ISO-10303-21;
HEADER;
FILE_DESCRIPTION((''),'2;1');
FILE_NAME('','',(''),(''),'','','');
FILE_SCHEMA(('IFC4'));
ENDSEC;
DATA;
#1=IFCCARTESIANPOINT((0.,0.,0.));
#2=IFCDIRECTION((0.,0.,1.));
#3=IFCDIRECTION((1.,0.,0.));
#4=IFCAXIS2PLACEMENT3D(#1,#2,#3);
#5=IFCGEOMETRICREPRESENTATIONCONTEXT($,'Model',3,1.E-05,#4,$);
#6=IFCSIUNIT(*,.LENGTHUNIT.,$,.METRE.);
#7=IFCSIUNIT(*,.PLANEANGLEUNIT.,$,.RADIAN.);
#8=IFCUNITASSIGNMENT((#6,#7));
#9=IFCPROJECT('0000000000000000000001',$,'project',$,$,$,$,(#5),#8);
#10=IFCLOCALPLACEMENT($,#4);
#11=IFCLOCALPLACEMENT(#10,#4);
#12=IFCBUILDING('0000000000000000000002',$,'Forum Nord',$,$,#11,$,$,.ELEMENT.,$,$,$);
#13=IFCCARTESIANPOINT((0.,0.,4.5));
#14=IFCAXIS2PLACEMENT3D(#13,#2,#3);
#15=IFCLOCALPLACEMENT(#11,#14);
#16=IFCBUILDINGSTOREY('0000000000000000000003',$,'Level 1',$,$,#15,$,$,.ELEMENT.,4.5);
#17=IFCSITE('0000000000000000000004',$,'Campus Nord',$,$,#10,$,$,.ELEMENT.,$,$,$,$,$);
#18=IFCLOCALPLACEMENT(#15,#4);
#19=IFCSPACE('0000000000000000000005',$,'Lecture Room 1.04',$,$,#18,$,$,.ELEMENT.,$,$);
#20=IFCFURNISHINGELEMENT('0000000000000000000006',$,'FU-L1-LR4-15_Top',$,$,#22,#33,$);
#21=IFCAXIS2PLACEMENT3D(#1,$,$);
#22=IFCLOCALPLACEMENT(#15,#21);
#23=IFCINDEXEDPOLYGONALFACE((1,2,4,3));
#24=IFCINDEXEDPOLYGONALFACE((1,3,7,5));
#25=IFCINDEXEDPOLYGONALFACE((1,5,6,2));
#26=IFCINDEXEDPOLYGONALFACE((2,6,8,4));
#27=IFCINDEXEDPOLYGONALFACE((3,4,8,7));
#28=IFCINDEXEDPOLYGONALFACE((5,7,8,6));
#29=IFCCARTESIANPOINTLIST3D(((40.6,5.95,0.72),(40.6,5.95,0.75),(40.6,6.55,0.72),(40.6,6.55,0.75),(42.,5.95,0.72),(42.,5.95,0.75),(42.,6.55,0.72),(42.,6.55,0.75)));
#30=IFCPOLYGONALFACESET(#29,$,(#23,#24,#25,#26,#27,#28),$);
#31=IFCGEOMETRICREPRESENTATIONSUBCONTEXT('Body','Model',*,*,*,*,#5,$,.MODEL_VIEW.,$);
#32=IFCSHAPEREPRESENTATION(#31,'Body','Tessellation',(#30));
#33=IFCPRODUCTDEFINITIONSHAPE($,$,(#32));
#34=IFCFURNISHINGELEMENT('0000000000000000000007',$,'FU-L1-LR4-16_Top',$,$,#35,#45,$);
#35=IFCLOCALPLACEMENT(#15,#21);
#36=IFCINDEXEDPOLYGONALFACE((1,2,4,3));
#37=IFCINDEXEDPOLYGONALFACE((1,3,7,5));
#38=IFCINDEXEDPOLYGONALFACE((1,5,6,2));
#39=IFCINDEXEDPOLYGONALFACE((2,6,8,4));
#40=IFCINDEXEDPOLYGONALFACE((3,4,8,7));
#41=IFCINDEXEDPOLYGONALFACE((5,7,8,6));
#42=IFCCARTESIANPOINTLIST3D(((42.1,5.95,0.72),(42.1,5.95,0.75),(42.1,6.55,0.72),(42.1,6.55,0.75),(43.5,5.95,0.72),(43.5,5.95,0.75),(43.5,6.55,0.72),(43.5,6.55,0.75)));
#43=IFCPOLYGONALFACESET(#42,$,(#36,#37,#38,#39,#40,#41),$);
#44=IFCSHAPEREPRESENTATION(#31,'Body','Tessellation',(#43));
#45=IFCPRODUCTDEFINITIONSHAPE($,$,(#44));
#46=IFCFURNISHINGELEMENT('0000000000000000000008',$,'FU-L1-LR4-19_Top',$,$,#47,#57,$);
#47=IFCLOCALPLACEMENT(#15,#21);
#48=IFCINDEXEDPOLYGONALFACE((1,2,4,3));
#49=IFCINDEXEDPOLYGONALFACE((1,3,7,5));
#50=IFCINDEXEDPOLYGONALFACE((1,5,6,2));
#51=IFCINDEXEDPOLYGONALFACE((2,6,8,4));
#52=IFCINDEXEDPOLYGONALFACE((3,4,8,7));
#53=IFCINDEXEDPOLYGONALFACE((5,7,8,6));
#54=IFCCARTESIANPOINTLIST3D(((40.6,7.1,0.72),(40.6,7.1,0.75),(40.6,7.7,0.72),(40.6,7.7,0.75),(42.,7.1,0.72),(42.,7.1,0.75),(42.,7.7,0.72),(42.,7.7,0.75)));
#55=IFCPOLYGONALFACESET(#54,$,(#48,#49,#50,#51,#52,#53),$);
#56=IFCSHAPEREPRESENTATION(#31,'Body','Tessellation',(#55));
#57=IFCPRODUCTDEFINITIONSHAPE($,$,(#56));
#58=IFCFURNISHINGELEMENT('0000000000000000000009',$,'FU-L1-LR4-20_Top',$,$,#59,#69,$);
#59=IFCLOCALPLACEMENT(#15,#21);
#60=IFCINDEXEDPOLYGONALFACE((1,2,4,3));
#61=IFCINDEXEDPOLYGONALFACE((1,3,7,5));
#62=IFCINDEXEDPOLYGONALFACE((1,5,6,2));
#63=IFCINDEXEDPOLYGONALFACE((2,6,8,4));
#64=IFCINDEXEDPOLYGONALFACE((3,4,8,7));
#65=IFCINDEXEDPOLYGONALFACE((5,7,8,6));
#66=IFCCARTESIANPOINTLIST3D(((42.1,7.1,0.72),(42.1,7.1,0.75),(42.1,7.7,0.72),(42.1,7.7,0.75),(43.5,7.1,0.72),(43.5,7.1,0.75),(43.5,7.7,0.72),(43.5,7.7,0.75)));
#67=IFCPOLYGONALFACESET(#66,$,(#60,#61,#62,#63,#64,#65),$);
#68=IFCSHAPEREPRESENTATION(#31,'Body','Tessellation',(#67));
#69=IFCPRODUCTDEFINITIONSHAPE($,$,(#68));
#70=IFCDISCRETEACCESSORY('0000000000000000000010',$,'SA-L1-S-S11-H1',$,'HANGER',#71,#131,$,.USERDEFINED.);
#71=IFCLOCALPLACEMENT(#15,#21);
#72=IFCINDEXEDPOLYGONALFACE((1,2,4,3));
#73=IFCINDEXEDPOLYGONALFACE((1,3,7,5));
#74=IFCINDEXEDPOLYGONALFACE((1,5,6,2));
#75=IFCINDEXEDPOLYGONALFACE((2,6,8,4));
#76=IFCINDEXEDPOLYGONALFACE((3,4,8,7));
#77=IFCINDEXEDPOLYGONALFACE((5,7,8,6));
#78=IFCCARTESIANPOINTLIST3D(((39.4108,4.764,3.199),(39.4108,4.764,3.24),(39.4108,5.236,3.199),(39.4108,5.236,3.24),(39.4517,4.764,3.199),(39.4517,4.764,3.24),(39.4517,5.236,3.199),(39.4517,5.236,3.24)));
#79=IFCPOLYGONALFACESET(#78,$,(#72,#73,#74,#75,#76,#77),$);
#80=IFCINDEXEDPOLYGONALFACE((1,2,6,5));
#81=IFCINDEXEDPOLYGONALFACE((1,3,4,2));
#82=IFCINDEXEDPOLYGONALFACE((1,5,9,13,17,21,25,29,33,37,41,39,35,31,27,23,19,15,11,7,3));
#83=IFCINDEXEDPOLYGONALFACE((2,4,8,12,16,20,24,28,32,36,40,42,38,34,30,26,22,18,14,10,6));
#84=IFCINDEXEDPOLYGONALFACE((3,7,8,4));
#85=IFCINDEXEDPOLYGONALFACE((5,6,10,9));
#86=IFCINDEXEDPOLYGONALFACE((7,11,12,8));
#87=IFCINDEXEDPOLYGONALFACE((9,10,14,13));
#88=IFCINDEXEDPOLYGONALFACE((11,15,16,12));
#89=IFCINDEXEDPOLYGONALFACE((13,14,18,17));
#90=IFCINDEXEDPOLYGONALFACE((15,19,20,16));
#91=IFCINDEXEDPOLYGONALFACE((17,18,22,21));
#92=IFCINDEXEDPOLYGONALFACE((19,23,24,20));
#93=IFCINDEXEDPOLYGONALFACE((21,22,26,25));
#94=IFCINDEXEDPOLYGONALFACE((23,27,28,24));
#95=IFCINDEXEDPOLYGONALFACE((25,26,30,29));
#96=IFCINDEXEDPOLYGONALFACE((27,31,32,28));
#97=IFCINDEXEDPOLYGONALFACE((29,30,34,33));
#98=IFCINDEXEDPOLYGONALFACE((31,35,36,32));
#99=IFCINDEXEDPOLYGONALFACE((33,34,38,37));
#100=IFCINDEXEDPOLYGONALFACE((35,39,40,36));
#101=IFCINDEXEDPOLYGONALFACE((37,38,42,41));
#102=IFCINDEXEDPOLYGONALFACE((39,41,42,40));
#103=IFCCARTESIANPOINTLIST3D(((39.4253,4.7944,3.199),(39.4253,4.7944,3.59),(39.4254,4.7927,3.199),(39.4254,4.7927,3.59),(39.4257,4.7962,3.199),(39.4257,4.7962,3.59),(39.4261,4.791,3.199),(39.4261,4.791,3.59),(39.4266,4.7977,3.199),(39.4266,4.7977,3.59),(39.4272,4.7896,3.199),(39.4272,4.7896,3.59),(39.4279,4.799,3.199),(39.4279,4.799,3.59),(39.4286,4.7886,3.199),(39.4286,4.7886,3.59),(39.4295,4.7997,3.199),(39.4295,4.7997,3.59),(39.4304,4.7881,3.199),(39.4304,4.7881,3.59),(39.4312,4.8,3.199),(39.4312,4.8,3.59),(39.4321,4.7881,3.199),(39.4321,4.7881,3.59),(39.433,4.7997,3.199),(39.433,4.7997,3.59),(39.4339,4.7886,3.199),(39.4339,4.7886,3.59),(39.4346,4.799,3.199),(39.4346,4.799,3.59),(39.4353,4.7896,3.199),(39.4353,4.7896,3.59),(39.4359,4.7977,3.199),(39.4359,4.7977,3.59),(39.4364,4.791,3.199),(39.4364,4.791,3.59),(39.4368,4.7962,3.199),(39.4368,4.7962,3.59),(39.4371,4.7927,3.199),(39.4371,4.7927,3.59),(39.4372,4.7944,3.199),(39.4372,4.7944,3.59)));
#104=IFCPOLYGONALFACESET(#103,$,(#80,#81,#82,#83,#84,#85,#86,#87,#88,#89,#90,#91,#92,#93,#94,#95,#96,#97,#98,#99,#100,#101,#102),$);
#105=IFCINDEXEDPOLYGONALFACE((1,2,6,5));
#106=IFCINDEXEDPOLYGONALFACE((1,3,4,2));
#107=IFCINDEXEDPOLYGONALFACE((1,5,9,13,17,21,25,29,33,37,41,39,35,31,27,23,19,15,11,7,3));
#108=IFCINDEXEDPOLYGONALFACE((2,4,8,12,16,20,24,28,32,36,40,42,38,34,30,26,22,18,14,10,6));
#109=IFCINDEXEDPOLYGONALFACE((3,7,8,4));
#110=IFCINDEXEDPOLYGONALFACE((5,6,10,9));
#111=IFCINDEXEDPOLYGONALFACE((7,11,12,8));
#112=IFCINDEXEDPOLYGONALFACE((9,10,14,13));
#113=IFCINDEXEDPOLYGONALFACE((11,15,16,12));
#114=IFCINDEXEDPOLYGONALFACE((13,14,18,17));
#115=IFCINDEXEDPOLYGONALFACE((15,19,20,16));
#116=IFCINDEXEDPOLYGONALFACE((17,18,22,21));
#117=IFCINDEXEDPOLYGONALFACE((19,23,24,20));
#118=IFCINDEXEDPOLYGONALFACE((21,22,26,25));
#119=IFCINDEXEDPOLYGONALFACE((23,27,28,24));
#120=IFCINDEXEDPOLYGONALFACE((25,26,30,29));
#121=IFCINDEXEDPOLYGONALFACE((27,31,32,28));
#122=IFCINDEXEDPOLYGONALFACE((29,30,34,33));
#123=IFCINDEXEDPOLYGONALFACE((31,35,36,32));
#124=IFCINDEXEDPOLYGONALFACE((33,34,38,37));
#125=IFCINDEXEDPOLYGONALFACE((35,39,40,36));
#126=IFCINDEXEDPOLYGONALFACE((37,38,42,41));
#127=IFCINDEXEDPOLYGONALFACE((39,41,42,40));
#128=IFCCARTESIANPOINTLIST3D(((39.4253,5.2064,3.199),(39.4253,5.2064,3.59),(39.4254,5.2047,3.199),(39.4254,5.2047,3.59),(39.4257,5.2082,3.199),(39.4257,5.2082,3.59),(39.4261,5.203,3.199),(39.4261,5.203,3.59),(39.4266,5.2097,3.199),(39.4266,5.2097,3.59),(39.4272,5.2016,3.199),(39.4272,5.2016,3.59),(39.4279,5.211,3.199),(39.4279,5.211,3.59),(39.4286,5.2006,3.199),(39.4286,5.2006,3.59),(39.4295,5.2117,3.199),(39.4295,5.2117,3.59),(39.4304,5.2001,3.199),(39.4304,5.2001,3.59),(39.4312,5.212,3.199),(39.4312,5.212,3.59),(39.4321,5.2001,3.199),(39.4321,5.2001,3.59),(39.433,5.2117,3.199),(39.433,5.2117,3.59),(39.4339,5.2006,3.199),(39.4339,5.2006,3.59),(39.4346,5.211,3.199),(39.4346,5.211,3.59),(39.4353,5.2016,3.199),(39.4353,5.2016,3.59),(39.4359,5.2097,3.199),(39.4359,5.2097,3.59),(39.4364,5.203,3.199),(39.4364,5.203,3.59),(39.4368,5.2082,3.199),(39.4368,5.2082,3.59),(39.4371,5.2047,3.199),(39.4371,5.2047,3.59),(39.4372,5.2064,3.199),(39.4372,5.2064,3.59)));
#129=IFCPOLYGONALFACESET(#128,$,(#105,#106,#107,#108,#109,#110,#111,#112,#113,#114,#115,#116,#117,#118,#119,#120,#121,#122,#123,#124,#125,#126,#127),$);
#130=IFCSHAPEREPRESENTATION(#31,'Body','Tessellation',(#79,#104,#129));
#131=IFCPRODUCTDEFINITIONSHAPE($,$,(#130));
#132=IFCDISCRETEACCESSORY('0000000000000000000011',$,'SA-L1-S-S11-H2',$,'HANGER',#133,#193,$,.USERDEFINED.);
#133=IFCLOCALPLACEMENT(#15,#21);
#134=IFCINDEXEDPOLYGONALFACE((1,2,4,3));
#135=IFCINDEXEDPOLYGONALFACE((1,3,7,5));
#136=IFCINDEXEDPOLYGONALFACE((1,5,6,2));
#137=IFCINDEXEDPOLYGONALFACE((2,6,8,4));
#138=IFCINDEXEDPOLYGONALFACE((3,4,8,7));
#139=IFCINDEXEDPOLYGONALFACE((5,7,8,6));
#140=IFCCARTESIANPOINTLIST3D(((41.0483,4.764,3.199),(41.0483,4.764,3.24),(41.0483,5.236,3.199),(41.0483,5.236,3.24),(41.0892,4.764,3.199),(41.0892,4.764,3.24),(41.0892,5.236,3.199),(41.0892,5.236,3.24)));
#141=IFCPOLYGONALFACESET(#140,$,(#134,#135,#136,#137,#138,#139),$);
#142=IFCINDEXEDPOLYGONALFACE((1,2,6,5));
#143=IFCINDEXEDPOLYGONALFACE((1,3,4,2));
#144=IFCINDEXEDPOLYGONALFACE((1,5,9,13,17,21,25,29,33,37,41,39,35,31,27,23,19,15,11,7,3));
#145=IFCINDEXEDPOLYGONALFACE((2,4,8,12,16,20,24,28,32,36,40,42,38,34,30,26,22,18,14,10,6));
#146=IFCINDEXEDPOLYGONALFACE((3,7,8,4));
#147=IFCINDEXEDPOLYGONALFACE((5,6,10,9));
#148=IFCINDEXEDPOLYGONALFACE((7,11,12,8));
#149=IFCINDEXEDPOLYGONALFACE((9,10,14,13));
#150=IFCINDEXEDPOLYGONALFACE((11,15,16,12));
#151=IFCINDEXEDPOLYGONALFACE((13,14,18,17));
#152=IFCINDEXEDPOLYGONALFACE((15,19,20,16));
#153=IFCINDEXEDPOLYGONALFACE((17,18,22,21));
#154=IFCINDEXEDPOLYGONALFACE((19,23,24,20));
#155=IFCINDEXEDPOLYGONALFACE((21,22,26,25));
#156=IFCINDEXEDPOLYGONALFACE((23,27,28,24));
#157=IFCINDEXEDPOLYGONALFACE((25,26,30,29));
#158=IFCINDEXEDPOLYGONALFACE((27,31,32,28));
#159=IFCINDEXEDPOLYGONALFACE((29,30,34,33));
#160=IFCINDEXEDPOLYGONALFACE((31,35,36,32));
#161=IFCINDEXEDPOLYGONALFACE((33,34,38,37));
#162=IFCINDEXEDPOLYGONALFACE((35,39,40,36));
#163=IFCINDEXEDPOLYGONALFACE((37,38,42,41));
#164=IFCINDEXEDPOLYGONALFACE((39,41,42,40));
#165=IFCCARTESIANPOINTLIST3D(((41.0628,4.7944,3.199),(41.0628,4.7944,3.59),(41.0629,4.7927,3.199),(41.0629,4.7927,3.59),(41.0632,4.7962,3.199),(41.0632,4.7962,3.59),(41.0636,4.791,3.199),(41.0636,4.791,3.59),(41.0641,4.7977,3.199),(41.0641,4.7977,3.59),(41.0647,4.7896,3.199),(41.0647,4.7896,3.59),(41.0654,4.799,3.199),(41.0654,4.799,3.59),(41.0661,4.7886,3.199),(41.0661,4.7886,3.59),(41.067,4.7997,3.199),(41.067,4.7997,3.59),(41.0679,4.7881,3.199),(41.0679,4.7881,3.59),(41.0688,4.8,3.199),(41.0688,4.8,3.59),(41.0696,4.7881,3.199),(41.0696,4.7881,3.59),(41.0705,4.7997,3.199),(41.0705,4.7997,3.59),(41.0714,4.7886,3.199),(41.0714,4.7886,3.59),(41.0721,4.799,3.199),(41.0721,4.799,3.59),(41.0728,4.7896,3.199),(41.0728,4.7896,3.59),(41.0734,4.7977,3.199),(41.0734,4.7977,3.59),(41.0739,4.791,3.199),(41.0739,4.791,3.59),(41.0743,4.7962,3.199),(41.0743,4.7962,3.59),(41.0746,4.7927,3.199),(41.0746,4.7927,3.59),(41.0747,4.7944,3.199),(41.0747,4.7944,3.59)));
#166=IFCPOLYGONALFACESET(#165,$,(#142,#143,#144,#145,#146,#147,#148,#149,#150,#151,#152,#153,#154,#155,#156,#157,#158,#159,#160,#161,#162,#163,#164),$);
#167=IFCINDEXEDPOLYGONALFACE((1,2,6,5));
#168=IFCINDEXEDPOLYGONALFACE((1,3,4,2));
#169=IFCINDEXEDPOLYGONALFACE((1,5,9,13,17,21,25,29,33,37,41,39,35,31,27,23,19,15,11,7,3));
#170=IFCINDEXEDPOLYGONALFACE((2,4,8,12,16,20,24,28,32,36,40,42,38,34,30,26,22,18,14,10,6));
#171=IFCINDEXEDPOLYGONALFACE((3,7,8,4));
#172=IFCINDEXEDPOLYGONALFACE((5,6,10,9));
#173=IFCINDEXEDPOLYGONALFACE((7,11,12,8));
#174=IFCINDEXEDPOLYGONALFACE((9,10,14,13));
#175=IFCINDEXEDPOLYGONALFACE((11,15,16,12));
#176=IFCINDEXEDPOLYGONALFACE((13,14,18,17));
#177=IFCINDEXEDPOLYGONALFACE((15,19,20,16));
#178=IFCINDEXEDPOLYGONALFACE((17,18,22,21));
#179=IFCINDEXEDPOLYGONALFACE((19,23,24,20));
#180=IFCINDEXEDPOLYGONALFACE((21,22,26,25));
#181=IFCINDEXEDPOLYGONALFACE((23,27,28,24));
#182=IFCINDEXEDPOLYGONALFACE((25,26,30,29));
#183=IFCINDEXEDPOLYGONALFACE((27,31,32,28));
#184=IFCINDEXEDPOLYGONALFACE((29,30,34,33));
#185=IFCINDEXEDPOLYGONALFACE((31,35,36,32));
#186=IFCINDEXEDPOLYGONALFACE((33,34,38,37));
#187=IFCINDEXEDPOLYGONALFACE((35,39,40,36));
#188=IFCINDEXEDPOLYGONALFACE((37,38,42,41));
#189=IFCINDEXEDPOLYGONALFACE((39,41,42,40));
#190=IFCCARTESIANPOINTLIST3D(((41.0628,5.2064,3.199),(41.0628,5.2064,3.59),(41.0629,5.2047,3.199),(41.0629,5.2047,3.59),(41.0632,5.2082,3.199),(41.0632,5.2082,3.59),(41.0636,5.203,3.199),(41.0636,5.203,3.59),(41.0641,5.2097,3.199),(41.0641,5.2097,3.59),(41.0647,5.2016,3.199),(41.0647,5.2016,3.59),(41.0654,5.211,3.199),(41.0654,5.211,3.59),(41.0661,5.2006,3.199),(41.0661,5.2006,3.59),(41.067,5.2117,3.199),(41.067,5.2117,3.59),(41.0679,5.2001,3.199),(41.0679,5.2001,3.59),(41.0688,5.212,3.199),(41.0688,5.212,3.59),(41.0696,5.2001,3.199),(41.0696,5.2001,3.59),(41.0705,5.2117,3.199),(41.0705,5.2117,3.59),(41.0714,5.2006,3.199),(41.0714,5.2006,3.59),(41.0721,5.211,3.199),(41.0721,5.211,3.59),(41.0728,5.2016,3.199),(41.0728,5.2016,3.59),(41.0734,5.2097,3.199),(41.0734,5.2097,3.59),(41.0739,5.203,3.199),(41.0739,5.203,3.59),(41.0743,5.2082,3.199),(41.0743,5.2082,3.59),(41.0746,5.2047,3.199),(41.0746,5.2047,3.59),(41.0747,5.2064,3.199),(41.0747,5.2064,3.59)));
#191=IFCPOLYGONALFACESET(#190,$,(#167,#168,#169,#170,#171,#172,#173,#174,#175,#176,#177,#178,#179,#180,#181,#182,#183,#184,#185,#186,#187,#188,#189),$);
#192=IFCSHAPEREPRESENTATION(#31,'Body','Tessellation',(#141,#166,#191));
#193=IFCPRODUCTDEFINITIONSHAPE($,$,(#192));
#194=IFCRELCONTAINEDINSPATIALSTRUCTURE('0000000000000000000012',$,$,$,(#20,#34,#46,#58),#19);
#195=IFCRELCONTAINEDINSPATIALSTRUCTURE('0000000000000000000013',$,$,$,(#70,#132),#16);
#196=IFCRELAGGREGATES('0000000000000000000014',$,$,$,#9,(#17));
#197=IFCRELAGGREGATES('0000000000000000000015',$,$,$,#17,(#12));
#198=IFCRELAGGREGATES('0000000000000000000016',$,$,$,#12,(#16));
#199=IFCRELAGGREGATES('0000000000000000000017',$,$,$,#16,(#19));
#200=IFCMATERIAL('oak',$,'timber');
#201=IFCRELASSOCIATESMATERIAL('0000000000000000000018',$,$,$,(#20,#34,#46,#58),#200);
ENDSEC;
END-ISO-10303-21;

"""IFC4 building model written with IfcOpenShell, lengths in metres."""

from ifc_helpers import new_model, si_unit, frame, frame_2d, origin_with_axes, origin_2d_with_axis, place, context, subcontext, project, spatial, rectangle, circle, extrude, material, element, save


model = new_model("IFC4")

# Units and contexts
model_context = context("Model", 3, precision=1e-05, world=origin_with_axes())
body_context = subcontext(model_context, "Body", "Model", "MODEL_VIEW")
ifc_project = project(units=[si_unit("LENGTHUNIT", "METRE"), si_unit("PLANEANGLEUNIT", "RADIAN")], contexts=[model_context])

# Site, building, storey
site_placement = place(None, origin_with_axes())
site = spatial("IfcSite", under=ifc_project, at=site_placement, Name="Campus Nord", CompositionType="ELEMENT")
building_placement = place(site_placement, origin_with_axes())
building = spatial("IfcBuilding", under=site, at=building_placement, Name="Forum Nord", CompositionType="ELEMENT")
storey_placement = place(building_placement, frame((0.0, 0.0, 4.5), z_axis=(0.0, 0.0, 1.0), x_axis=(1.0, 0.0, 0.0)))
storey = spatial("IfcBuildingStorey", under=building, at=storey_placement, Name="Level 1", CompositionType="ELEMENT", Elevation=4.5)

# Shared definitions
space_placement = place(storey_placement, origin_with_axes())
space = spatial("IfcSpace", under=storey, at=space_placement, Name="Lecture Room 1.04", CompositionType="ELEMENT")

# Furnishing elements
ifc_material_1 = material(Name="oak", Category="timber")
furnishing_1_placement = place(storey_placement, frame((40.6, 5.95, 0.0), z_axis=(0.0, 0.0, 1.0), x_axis=(1.0, 0.0, 0.0)))
element("IfcFurnishingElement", 1, at=furnishing_1_placement, inside=space, material=ifc_material_1, Name="FU-L1-LR4-15_Top", context=body_context, shape_type="SweptSolid", body=[
    extrude(rectangle(XDim=1.4, YDim=0.6, at=frame_2d((0.7, 0.3), x_axis=(1.0, 0.0))), frame((0.0, 0.0, 0.72), z_axis=(0.0, 0.0, 1.0), x_axis=(1.0, 0.0, 0.0)), (0.0, 0.0, 1.0), 0.03),
])
furnishing_2_placement = place(storey_placement, frame((42.1, 5.95, 0.0), z_axis=(0.0, 0.0, 1.0), x_axis=(1.0, 0.0, 0.0)))
element("IfcFurnishingElement", 2, at=furnishing_2_placement, inside=space, material=ifc_material_1, Name="FU-L1-LR4-16_Top", context=body_context, shape_type="SweptSolid", body=[
    extrude(rectangle(XDim=1.4, YDim=0.6, at=frame_2d((0.7, 0.3), x_axis=(1.0, 0.0))), frame((0.0, 0.0, 0.72), z_axis=(0.0, 0.0, 1.0), x_axis=(1.0, 0.0, 0.0)), (0.0, 0.0, 1.0), 0.03),
])
furnishing_3_placement = place(storey_placement, frame((40.6, 7.1, 0.0), z_axis=(0.0, 0.0, 1.0), x_axis=(1.0, 0.0, 0.0)))
element("IfcFurnishingElement", 3, at=furnishing_3_placement, inside=space, material=ifc_material_1, Name="FU-L1-LR4-19_Top", context=body_context, shape_type="SweptSolid", body=[
    extrude(rectangle(XDim=1.4, YDim=0.6, at=frame_2d((0.7, 0.3), x_axis=(1.0, 0.0))), frame((0.0, 0.0, 0.72), z_axis=(0.0, 0.0, 1.0), x_axis=(1.0, 0.0, 0.0)), (0.0, 0.0, 1.0), 0.03),
])
furnishing_4_placement = place(storey_placement, frame((42.1, 7.1, 0.0), z_axis=(0.0, 0.0, 1.0), x_axis=(1.0, 0.0, 0.0)))
element("IfcFurnishingElement", 4, at=furnishing_4_placement, inside=space, material=ifc_material_1, Name="FU-L1-LR4-20_Top", context=body_context, shape_type="SweptSolid", body=[
    extrude(rectangle(XDim=1.4, YDim=0.6, at=frame_2d((0.7, 0.3), x_axis=(1.0, 0.0))), frame((0.0, 0.0, 0.72), z_axis=(0.0, 0.0, 1.0), x_axis=(1.0, 0.0, 0.0)), (0.0, 0.0, 1.0), 0.03),
])

# Discrete accessories
for number, where, z_axis, x_axis, name in (
    (5, (39.4312, 5.0, 3.24), (0.0, 0.0, 1.0), (0.0, 1.0, 0.0), "SA-L1-S-S11-H1"),
    (6, (41.0688, 5.0, 3.24), (0.0, 0.0, 1.0), (0.0, 1.0, 0.0), "SA-L1-S-S11-H2"),
):
    element("IfcDiscreteAccessory", number, at=place(storey_placement, frame(where, z_axis=z_axis, x_axis=x_axis)), inside=storey, Name=name, ObjectType="HANGER", PredefinedType="USERDEFINED", context=body_context, shape_type="SweptSolid", body=[
        extrude(rectangle(XDim=0.472, YDim=0.041, at=origin_2d_with_axis()), frame((0.0, 0.0, -0.041), z_axis=(0.0, 0.0, 1.0), x_axis=(1.0, 0.0, 0.0)), (0.0, 0.0, 1.0), 0.041),
        extrude(circle(Radius=0.006, at=frame_2d((-0.206, 0.0), x_axis=(1.0, 0.0))), frame((0.0, 0.0, -0.041), z_axis=(0.0, 0.0, 1.0), x_axis=(1.0, 0.0, 0.0)), (0.0, 0.0, 1.0), 0.391),
        extrude(circle(Radius=0.006, at=frame_2d((0.206, 0.0), x_axis=(1.0, 0.0))), frame((0.0, 0.0, -0.041), z_axis=(0.0, 0.0, 1.0), x_axis=(1.0, 0.0, 0.0)), (0.0, 0.0, 1.0), 0.391),
    ])

save(model, "model.ifc")
